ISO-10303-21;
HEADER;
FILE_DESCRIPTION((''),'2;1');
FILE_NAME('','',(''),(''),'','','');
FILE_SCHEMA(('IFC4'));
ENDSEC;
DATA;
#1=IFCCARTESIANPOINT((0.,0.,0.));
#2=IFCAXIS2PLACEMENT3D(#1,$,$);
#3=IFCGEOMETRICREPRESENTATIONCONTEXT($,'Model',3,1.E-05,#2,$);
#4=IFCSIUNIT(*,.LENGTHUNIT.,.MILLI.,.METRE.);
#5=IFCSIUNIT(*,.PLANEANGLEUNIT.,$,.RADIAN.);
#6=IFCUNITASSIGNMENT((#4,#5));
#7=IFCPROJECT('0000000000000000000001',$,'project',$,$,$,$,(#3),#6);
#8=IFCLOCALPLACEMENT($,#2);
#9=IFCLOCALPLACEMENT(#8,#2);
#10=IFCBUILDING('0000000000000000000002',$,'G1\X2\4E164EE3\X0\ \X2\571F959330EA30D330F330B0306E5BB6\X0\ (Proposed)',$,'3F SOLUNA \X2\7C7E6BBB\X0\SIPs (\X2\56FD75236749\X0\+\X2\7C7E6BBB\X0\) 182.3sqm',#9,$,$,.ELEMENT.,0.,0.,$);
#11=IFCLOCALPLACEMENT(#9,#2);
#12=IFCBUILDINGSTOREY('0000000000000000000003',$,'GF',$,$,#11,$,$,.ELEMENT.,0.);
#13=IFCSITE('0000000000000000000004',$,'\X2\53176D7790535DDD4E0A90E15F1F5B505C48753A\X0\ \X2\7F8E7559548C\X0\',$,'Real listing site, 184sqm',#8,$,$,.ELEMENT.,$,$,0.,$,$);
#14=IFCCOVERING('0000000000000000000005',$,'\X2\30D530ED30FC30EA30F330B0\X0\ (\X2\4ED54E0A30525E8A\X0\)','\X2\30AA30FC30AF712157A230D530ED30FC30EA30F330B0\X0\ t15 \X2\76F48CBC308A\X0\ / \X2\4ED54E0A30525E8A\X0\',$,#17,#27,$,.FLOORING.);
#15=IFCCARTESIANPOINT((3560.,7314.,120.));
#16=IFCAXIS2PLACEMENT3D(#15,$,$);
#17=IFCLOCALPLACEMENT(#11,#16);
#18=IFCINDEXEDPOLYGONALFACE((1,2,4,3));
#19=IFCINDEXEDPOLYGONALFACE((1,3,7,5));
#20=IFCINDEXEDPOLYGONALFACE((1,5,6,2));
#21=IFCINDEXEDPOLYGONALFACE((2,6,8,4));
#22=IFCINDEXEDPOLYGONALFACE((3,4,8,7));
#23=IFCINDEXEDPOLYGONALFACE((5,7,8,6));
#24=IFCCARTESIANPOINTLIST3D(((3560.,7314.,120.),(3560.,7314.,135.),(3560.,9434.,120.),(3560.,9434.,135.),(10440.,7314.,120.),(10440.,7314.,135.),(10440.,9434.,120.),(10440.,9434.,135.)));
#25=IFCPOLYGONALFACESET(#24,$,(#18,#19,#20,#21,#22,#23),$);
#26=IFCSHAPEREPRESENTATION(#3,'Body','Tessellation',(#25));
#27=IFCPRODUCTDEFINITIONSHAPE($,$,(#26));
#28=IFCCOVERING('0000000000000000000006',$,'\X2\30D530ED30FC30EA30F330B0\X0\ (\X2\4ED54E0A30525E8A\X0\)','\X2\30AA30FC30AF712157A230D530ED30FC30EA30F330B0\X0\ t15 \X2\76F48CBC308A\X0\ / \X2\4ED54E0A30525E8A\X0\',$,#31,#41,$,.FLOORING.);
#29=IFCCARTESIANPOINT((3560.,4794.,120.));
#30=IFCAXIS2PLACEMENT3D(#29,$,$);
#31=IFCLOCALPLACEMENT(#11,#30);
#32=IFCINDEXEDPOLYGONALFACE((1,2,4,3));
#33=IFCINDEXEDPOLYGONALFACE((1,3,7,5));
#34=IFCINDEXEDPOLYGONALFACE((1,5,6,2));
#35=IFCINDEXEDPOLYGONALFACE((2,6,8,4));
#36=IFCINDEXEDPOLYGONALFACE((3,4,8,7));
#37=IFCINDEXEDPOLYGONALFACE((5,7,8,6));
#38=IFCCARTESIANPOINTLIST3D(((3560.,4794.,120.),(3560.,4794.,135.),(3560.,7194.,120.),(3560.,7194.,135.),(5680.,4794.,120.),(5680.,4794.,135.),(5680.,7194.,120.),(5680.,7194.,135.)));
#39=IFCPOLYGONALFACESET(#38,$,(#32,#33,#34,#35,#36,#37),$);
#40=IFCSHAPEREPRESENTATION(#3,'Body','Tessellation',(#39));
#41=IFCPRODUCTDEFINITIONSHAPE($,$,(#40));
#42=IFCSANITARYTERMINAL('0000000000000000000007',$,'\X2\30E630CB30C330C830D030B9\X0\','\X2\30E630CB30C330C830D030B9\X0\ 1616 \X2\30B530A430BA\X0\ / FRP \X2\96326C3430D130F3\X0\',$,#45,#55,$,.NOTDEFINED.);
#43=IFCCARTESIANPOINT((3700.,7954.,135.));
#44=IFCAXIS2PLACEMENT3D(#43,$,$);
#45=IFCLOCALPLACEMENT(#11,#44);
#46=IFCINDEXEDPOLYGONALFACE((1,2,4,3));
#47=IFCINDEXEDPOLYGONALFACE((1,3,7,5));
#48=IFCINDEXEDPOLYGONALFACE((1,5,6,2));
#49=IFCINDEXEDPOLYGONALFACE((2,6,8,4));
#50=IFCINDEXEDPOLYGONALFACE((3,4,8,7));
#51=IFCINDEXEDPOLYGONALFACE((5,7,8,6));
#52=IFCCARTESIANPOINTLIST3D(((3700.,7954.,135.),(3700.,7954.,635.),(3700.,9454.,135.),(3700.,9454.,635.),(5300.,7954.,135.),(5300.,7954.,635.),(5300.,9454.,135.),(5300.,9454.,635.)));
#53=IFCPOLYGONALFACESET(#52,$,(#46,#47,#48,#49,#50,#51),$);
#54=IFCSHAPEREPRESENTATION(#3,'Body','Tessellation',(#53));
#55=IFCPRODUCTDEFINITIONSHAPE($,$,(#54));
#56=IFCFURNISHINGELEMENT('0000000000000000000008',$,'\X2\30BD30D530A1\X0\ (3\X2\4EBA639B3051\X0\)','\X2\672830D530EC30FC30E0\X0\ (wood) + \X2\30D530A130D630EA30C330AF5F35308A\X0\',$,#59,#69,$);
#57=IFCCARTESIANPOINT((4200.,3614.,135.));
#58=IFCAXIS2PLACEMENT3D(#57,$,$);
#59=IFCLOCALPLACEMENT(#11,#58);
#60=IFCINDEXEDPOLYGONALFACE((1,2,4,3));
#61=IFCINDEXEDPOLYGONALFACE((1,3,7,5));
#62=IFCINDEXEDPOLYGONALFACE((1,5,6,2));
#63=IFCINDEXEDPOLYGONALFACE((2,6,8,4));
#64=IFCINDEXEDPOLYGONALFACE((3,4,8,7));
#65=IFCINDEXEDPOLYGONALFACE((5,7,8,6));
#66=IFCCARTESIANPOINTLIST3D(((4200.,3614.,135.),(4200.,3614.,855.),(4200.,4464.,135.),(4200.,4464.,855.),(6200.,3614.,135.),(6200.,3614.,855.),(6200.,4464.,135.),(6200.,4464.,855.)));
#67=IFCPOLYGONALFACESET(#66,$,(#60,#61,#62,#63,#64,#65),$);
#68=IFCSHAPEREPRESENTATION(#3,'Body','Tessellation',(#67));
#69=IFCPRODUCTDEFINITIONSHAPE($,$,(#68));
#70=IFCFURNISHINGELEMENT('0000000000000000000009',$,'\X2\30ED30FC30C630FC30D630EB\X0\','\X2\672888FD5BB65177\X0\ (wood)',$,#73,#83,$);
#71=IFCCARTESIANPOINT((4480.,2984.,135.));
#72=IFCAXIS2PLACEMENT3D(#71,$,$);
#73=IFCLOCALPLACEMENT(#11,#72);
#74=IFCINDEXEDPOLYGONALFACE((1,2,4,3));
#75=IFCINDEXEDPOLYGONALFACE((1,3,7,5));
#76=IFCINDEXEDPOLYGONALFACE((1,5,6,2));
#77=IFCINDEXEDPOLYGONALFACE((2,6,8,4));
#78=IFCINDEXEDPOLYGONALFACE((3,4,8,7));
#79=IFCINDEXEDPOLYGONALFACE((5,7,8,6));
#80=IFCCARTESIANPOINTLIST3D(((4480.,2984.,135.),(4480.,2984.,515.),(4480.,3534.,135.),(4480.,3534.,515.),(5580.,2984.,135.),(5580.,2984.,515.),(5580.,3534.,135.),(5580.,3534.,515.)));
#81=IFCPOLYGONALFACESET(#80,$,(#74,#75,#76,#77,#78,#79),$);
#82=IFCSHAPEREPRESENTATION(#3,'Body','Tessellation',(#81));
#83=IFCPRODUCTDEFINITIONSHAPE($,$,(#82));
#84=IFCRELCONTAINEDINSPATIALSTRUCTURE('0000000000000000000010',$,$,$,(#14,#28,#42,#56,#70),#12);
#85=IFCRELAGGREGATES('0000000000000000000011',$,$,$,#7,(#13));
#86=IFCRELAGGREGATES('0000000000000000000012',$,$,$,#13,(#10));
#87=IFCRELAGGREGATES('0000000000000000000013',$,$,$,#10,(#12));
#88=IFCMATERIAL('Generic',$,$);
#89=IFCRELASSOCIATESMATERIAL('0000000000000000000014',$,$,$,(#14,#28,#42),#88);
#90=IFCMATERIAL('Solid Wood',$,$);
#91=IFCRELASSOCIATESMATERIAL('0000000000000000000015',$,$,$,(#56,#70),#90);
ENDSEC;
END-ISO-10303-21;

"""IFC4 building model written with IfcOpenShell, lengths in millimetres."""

from ifc_helpers import new_model, si_unit, frame, frame_2d, origin, place, context, project, spatial, rectangle, extrude, material, element, save


model = new_model("IFC4")

# Units and contexts
model_context = context("Model", 3, precision=1e-05, world=origin())
ifc_project = project(units=[si_unit("LENGTHUNIT", "METRE", prefix="MILLI"), si_unit("PLANEANGLEUNIT", "RADIAN")], contexts=[model_context])

# Site, building, storey
site_placement = place(None, origin())
site = spatial("IfcSite", under=ifc_project, at=site_placement, Name="北海道川上郡弟子屈町 美留和", ObjectType="Real listing site, 184sqm", CompositionType="ELEMENT", RefElevation=0.0)
building_placement = place(site_placement, origin())
building = spatial("IfcBuilding", under=site, at=building_placement, Name="G1世代 土間リビングの家 (Proposed)", ObjectType="3F SOLUNA 籾殻SIPs (国産杉+籾殻) 182.3sqm", CompositionType="ELEMENT", ElevationOfRefHeight=0.0, ElevationOfTerrain=0.0)
storey_placement = place(building_placement, origin())
storey = spatial("IfcBuildingStorey", under=building, at=storey_placement, Name="GF", CompositionType="ELEMENT", Elevation=0.0)

# Shared definitions
ifc_material_1 = material(Name="Solid Wood")

# Coverings
ifc_material_2 = material(Name="Generic")
covering_1_placement = place(storey_placement, frame((3560.0, 7314.0, 120.0)))
element("IfcCovering", 1, at=covering_1_placement, inside=storey, material=ifc_material_2, Name="フローリング (仕上げ床)", Description="オーク無垢フローリング t15 直貼り / 仕上げ床", PredefinedType="FLOORING", context=model_context, shape_type="SweptSolid", body=[
    extrude(rectangle(XDim=6880.0, YDim=2120.0, at=frame_2d((3440.0, 1060.0))), frame((3560.0, 7314.0, 120.0)), (0.0, 0.0, 1.0), 15.0),
])
covering_2_placement = place(storey_placement, frame((3560.0, 4794.0, 120.0)))
element("IfcCovering", 2, at=covering_2_placement, inside=storey, material=ifc_material_2, Name="フローリング (仕上げ床)", Description="オーク無垢フローリング t15 直貼り / 仕上げ床", PredefinedType="FLOORING", context=model_context, shape_type="SweptSolid", body=[
    extrude(rectangle(XDim=2120.0, YDim=2400.0, at=frame_2d((1060.0, 1200.0))), frame((3560.0, 4794.0, 120.0)), (0.0, 0.0, 1.0), 15.0),
])

# Sanitary terminal
sanitary_terminal_placement = place(storey_placement, frame((3700.0, 7954.0, 135.0)))
element("IfcSanitaryTerminal", 3, at=sanitary_terminal_placement, inside=storey, material=ifc_material_2, Name="ユニットバス", Description="ユニットバス 1616 サイズ / FRP 防水パン", PredefinedType="NOTDEFINED", context=model_context, shape_type="SweptSolid", body=[
    extrude(rectangle(XDim=1600.0, YDim=1500.0, at=frame_2d((800.0, 750.0))), frame((3700.0, 7954.0, 135.0)), (0.0, 0.0, 1.0), 500.0),
])

# Furnishing elements
furnishing_1_placement = place(storey_placement, frame((4200.0, 3614.0, 135.0)))
element("IfcFurnishingElement", 4, at=furnishing_1_placement, inside=storey, material=ifc_material_1, Name="ソファ (3人掛け)", Description="木フレーム (wood) + ファブリック張り", context=model_context, shape_type="SweptSolid", body=[
    extrude(rectangle(XDim=2000.0, YDim=850.0, at=frame_2d((1000.0, 425.0))), frame((4200.0, 3614.0, 135.0)), (0.0, 0.0, 1.0), 720.0),
])
furnishing_2_placement = place(storey_placement, frame((4480.0, 2984.0, 135.0)))
element("IfcFurnishingElement", 5, at=furnishing_2_placement, inside=storey, material=ifc_material_1, Name="ローテーブル", Description="木製家具 (wood)", context=model_context, shape_type="SweptSolid", body=[
    extrude(rectangle(XDim=1100.0, YDim=550.0, at=frame_2d((550.0, 275.0))), frame((4480.0, 2984.0, 135.0)), (0.0, 0.0, 1.0), 380.0),
])

save(model, "model.ifc")
